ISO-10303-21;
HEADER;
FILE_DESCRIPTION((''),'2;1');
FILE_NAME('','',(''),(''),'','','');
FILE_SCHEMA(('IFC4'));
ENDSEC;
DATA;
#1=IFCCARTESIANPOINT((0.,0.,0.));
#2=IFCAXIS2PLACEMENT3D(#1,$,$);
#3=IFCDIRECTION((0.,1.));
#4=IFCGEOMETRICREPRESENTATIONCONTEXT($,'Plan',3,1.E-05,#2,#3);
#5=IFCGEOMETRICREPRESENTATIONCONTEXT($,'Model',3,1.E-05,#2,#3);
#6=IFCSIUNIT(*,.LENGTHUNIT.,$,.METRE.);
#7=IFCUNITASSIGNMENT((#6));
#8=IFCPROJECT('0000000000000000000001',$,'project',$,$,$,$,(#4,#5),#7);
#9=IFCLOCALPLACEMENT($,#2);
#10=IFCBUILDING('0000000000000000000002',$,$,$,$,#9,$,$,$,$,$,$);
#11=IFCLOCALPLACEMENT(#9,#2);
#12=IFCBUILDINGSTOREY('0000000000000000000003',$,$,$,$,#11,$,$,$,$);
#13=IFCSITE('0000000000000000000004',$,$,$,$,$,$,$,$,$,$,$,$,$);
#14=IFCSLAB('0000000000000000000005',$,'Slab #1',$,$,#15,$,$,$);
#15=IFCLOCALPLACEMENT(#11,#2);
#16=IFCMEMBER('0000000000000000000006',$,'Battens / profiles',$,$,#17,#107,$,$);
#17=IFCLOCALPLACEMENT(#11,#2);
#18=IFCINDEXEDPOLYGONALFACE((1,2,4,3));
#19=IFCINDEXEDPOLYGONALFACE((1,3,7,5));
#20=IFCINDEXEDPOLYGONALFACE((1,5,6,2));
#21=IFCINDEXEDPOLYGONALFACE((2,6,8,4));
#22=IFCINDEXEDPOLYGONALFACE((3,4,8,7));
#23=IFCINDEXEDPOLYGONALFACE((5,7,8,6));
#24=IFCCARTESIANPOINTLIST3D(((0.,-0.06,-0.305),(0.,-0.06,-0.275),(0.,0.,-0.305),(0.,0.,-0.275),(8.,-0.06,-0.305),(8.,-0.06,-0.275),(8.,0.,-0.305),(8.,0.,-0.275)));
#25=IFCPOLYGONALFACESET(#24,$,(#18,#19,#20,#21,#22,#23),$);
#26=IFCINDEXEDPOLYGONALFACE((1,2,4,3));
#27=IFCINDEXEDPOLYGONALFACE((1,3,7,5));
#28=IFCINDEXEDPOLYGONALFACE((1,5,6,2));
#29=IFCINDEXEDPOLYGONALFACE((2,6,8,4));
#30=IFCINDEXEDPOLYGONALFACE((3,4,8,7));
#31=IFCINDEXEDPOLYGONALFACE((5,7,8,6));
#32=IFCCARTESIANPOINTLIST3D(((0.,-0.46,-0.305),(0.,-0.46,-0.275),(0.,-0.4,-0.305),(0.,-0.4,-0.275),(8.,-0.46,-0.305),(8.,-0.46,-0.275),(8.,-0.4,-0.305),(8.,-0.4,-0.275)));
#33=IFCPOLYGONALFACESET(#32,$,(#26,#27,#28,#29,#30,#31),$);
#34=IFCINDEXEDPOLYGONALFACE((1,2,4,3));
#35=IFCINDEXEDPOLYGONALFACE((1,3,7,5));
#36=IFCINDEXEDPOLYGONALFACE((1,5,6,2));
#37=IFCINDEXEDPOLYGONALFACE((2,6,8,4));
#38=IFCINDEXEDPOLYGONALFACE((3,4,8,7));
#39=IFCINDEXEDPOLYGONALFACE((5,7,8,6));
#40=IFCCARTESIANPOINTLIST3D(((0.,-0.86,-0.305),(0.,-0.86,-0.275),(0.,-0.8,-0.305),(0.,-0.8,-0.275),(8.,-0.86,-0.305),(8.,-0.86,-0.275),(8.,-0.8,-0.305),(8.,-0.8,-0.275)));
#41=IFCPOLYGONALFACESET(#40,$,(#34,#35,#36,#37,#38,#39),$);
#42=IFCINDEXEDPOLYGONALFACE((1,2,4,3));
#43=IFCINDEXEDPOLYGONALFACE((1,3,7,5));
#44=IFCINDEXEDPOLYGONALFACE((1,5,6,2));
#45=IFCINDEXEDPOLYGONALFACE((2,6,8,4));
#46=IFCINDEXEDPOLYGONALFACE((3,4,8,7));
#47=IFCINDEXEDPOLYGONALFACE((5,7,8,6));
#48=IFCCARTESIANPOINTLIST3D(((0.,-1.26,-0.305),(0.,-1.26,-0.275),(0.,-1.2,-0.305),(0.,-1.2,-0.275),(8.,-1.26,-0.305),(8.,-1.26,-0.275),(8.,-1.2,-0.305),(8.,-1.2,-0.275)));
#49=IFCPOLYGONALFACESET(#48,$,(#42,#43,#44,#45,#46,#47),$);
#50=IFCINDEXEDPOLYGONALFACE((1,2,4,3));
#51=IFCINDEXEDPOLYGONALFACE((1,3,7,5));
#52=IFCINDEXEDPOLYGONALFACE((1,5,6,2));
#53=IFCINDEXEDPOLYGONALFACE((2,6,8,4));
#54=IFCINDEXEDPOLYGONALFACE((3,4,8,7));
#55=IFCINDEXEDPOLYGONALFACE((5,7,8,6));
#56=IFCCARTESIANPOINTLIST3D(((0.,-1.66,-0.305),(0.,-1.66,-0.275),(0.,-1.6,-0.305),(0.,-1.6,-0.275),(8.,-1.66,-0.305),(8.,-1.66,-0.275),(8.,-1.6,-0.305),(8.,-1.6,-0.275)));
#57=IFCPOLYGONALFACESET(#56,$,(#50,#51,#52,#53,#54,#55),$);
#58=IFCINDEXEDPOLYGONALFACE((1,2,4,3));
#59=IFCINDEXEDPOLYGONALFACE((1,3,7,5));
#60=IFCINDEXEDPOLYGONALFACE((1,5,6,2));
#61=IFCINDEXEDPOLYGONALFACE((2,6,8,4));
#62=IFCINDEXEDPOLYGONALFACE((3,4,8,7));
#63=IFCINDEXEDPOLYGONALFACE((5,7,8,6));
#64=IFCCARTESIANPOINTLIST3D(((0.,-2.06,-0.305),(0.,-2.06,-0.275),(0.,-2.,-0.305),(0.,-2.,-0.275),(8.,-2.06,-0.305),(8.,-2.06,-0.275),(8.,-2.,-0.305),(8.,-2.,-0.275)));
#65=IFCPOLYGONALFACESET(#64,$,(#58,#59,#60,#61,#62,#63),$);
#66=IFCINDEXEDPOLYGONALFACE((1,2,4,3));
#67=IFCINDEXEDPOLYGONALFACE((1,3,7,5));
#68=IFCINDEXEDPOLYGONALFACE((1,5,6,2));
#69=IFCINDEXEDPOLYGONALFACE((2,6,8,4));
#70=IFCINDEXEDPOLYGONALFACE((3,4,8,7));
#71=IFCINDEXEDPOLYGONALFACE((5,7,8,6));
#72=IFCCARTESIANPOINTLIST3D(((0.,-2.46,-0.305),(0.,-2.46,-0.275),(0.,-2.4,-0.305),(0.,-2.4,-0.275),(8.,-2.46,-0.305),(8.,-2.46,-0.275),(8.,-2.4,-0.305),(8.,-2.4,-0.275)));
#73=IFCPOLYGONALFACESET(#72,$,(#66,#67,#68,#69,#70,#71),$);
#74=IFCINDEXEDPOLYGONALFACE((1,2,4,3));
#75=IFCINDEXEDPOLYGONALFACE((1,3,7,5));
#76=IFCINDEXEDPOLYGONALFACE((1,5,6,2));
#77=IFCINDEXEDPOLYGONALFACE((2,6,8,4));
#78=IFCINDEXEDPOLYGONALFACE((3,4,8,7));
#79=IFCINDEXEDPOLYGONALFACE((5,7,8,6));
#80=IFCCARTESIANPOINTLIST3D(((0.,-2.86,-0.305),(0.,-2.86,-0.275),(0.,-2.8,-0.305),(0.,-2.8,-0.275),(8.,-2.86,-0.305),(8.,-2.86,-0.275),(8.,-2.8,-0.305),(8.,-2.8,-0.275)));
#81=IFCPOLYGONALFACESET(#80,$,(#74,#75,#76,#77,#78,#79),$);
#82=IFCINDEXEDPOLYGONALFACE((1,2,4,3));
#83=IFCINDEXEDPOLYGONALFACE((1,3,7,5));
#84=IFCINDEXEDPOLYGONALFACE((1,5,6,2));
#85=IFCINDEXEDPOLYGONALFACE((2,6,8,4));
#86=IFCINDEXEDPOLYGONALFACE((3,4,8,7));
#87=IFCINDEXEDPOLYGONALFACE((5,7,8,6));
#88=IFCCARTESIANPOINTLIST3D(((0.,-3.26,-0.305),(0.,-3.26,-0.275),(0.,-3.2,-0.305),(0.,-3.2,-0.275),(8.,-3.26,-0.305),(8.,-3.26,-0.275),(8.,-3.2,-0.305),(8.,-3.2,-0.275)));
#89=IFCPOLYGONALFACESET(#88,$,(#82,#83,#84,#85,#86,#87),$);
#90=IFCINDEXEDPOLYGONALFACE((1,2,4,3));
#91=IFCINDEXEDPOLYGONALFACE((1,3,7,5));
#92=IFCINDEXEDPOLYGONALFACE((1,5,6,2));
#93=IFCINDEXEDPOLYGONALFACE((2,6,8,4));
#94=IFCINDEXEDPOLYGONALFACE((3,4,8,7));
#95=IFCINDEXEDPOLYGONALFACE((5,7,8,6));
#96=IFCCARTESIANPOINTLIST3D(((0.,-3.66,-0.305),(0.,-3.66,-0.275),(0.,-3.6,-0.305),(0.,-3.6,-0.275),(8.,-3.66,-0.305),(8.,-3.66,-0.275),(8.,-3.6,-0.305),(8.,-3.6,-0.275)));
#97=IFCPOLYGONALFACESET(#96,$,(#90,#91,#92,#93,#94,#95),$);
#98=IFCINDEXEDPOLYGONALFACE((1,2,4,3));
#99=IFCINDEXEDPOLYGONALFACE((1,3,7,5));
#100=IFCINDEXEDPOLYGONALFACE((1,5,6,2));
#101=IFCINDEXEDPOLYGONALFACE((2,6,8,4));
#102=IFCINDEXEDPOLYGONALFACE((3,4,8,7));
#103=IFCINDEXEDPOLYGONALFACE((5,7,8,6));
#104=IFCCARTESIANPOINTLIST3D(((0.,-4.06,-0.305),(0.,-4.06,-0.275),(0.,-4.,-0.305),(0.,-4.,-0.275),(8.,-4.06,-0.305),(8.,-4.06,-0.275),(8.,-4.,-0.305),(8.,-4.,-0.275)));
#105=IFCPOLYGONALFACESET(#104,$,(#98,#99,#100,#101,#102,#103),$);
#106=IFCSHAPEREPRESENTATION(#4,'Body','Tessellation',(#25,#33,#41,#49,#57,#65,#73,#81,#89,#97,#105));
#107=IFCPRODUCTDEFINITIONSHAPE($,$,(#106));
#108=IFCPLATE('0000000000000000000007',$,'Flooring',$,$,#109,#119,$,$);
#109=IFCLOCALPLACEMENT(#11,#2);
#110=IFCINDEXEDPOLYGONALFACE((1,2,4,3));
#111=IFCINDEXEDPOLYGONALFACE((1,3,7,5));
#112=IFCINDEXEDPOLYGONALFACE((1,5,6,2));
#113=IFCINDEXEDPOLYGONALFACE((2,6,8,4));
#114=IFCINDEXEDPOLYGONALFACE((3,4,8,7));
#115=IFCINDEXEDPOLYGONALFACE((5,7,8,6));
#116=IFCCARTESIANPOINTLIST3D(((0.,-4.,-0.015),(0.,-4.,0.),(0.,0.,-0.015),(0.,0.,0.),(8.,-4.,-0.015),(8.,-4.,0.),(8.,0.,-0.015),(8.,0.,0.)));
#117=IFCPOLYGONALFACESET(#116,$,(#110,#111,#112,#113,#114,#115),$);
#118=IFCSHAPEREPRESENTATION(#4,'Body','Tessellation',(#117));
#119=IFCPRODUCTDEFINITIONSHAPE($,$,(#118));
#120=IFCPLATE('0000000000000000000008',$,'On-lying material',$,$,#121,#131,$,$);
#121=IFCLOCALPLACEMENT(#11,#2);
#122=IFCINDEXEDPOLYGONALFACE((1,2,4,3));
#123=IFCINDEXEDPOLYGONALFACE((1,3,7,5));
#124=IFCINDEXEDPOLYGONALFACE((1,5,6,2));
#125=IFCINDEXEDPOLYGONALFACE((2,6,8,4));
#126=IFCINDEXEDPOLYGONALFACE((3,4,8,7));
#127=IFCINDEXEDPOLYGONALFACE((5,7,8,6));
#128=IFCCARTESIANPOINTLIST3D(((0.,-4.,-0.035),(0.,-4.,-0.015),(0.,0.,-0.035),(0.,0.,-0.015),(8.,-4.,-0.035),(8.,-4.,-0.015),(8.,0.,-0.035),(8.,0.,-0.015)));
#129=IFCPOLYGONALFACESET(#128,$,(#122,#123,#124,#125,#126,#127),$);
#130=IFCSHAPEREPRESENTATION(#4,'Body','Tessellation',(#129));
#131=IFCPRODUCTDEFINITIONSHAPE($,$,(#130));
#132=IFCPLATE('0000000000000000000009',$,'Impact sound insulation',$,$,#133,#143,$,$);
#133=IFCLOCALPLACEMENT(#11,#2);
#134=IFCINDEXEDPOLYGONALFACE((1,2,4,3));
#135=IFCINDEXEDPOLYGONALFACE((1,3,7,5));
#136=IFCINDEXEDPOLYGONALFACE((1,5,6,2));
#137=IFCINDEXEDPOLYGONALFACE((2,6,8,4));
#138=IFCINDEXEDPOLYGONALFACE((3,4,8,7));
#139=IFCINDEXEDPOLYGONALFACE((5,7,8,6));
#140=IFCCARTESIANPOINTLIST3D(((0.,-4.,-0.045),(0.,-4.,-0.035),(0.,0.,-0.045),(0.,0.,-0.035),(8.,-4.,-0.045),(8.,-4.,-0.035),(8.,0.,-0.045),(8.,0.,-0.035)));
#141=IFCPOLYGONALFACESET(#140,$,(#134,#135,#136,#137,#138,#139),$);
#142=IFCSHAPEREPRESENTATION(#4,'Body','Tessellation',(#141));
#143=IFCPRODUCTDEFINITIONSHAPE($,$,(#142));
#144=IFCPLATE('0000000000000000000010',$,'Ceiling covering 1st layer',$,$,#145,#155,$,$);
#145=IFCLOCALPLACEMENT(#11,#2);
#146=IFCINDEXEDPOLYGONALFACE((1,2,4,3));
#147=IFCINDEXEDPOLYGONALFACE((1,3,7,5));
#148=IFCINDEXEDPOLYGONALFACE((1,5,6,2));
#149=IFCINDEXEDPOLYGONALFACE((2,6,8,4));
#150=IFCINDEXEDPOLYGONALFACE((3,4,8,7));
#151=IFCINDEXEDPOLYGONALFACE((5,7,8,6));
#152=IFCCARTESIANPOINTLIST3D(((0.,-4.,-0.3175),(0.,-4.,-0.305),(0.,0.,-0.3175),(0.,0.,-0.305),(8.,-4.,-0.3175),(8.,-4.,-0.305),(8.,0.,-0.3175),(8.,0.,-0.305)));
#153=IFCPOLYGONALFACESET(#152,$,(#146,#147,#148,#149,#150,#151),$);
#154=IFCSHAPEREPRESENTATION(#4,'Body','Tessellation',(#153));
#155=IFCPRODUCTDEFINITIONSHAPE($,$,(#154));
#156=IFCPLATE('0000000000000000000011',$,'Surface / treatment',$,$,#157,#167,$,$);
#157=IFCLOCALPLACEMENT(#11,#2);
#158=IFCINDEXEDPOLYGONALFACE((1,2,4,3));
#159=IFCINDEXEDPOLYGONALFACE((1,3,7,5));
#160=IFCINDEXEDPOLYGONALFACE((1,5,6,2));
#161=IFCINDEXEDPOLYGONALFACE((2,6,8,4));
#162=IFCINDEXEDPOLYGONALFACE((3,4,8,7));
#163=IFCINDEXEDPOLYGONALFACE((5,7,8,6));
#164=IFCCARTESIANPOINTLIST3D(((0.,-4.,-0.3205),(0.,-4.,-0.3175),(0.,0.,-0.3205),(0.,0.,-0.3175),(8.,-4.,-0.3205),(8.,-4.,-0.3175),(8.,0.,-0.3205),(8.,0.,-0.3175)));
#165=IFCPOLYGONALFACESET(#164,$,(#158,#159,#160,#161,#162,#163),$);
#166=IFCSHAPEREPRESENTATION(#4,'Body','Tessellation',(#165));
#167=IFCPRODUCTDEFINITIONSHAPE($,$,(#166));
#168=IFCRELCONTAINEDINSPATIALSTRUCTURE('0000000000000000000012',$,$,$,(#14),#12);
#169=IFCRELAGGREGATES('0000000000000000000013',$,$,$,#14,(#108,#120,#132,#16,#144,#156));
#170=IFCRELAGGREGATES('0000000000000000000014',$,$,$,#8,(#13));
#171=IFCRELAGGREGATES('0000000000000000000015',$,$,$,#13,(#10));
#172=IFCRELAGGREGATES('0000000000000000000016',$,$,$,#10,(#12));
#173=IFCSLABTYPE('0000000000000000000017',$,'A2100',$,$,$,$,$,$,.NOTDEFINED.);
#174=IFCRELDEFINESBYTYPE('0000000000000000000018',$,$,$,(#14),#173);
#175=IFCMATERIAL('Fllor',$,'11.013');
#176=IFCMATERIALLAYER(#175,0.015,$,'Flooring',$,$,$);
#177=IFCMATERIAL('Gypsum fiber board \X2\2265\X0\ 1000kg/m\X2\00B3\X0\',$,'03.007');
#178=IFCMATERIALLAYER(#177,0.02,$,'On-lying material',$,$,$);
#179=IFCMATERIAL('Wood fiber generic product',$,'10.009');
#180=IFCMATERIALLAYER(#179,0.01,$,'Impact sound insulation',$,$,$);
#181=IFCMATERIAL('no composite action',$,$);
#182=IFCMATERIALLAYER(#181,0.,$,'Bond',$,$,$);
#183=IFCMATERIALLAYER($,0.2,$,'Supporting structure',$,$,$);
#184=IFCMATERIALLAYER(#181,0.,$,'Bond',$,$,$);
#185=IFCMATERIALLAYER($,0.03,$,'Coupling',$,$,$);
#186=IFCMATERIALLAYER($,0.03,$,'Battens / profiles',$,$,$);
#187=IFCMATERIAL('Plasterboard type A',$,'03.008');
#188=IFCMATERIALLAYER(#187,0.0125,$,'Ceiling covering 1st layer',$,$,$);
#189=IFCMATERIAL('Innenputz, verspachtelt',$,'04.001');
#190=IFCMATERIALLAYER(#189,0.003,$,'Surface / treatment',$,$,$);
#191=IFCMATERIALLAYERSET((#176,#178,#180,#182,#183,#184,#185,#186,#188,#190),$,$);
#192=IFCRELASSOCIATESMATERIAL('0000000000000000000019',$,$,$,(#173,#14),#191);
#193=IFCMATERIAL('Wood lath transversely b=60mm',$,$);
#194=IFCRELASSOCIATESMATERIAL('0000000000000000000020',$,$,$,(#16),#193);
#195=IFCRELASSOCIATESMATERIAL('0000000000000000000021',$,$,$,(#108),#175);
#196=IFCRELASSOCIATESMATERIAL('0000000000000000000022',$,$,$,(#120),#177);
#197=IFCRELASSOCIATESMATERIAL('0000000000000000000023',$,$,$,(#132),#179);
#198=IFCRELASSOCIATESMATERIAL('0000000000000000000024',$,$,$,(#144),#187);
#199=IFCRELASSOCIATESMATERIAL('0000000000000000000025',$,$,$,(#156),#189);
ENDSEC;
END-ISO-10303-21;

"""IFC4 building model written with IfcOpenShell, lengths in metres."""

from ifc_helpers import new_model, si_unit, direction, frame, frame_2d, origin, origin_with_axes, place, context, project, spatial, rectangle, extrude, material, layer, layer_set, type_object, element, aggregate, save


model = new_model("IFC4")

# Units and contexts
plan_context = context("Plan", 3, precision=1e-05, world=origin(), true_north=direction((0.0, 1.0)))
model_context = context("Model", 3, precision=1e-05, world=origin(), true_north=direction((0.0, 1.0)))
ifc_project = project(units=[si_unit("LENGTHUNIT", "METRE")], contexts=[plan_context, model_context])

# Site, building, storey
site = spatial("IfcSite", under=ifc_project)
building_placement = place(None, origin())
building = spatial("IfcBuilding", under=site, at=building_placement)
storey_placement = place(building_placement, origin())
storey = spatial("IfcBuildingStorey", under=building, at=storey_placement)

# Slab, member, plates
ifc_material_1 = material(Name="Fllor", Category="11.013")
ifc_layer_1 = layer(ifc_material_1, 0.015, Name="Flooring")
ifc_material_2 = material(Name="Gypsum fiber board ≥ 1000kg/m³", Category="03.007")
ifc_layer_2 = layer(ifc_material_2, 0.02, Name="On-lying material")
ifc_material_3 = material(Name="Wood fiber generic product", Category="10.009")
ifc_layer_3 = layer(ifc_material_3, 0.01, Name="Impact sound insulation")
ifc_material_4 = material(Name="no composite action")
ifc_layer_4 = layer(ifc_material_4, 0.0, Name="Bond")
ifc_layer_5 = layer(None, 0.2, Name="Supporting structure")
ifc_layer_6 = layer(ifc_material_4, 0.0, Name="Bond")
ifc_layer_7 = layer(None, 0.03, Name="Coupling")
ifc_layer_8 = layer(None, 0.03, Name="Battens / profiles")
ifc_material_5 = material(Name="Plasterboard type A", Category="03.008")
ifc_layer_9 = layer(ifc_material_5, 0.0125, Name="Ceiling covering 1st layer")
ifc_material_6 = material(Name="Innenputz, verspachtelt", Category="04.001")
ifc_layer_10 = layer(ifc_material_6, 0.003, Name="Surface / treatment")
ifc_layer_set = layer_set([ifc_layer_1, ifc_layer_2, ifc_layer_3, ifc_layer_4, ifc_layer_5, ifc_layer_6, ifc_layer_7, ifc_layer_8, ifc_layer_9, ifc_layer_10])
slab_type = type_object("IfcSlabType", Name="A2100", PredefinedType="NOTDEFINED", material=ifc_layer_set)
slab_placement = place(None, frame((0.0, 0.0, 0.0), z_axis=(0.0, 0.0, -1.0), x_axis=(1.0, 0.0, 0.0)))
slab = element("IfcSlab", 1, at=slab_placement, inside=storey, type_object=slab_type, material=ifc_layer_set, Name="Slab #1")
ifc_material_7 = material(Name="Wood lath transversely b=60mm")
member_1_placement = place(slab_placement, origin())
member_1 = element("IfcMember", 2, at=member_1_placement, material=ifc_material_7, Name="Battens / profiles", context=plan_context, shape_type="SweptSolid", body=[
    extrude(rectangle(XDim=0.06, YDim=0.03, at=frame_2d((0.03, 0.015), x_axis=(1.0, 0.0))), frame((0.0, 0.0, 0.275), z_axis=(1.0, 0.0, 0.0), x_axis=(0.0, 1.0, 0.0)), (0.0, 0.0, 1.0), 8.0),
    extrude(rectangle(XDim=0.06, YDim=0.03, at=frame_2d((0.03, 0.015), x_axis=(1.0, 0.0))), frame((0.0, 0.4, 0.275), z_axis=(1.0, 0.0, 0.0), x_axis=(0.0, 1.0, 0.0)), (0.0, 0.0, 1.0), 8.0),
    extrude(rectangle(XDim=0.06, YDim=0.03, at=frame_2d((0.03, 0.015), x_axis=(1.0, 0.0))), frame((0.0, 0.8, 0.275), z_axis=(1.0, 0.0, 0.0), x_axis=(0.0, 1.0, 0.0)), (0.0, 0.0, 1.0), 8.0),
    extrude(rectangle(XDim=0.06, YDim=0.03, at=frame_2d((0.03, 0.015), x_axis=(1.0, 0.0))), frame((0.0, 1.2, 0.275), z_axis=(1.0, 0.0, 0.0), x_axis=(0.0, 1.0, 0.0)), (0.0, 0.0, 1.0), 8.0),
    extrude(rectangle(XDim=0.06, YDim=0.03, at=frame_2d((0.03, 0.015), x_axis=(1.0, 0.0))), frame((0.0, 1.6, 0.275), z_axis=(1.0, 0.0, 0.0), x_axis=(0.0, 1.0, 0.0)), (0.0, 0.0, 1.0), 8.0),
    extrude(rectangle(XDim=0.06, YDim=0.03, at=frame_2d((0.03, 0.015), x_axis=(1.0, 0.0))), frame((0.0, 2.0, 0.275), z_axis=(1.0, 0.0, 0.0), x_axis=(0.0, 1.0, 0.0)), (0.0, 0.0, 1.0), 8.0),
    extrude(rectangle(XDim=0.06, YDim=0.03, at=frame_2d((0.03, 0.015), x_axis=(1.0, 0.0))), frame((0.0, 2.4, 0.275), z_axis=(1.0, 0.0, 0.0), x_axis=(0.0, 1.0, 0.0)), (0.0, 0.0, 1.0), 8.0),
    extrude(rectangle(XDim=0.06, YDim=0.03, at=frame_2d((0.03, 0.015), x_axis=(1.0, 0.0))), frame((0.0, 2.8, 0.275), z_axis=(1.0, 0.0, 0.0), x_axis=(0.0, 1.0, 0.0)), (0.0, 0.0, 1.0), 8.0),
    extrude(rectangle(XDim=0.06, YDim=0.03, at=frame_2d((0.03, 0.015), x_axis=(1.0, 0.0))), frame((0.0, 3.2, 0.275), z_axis=(1.0, 0.0, 0.0), x_axis=(0.0, 1.0, 0.0)), (0.0, 0.0, 1.0), 8.0),
    extrude(rectangle(XDim=0.06, YDim=0.03, at=frame_2d((0.03, 0.015), x_axis=(1.0, 0.0))), frame((0.0, 3.6, 0.275), z_axis=(1.0, 0.0, 0.0), x_axis=(0.0, 1.0, 0.0)), (0.0, 0.0, 1.0), 8.0),
    extrude(rectangle(XDim=0.06, YDim=0.03, at=frame_2d((0.03, 0.015), x_axis=(1.0, 0.0))), frame((0.0, 4.0, 0.275), z_axis=(1.0, 0.0, 0.0), x_axis=(0.0, 1.0, 0.0)), (0.0, 0.0, 1.0), 8.0),
])
plate_1_placement = place(slab_placement, origin())
plate_1 = element("IfcPlate", 3, at=plate_1_placement, material=ifc_material_1, Name="Flooring", context=plan_context, shape_type="SweptSolid", body=[
    extrude(rectangle(XDim=8.0, YDim=4.0, at=frame_2d((4.0, 2.0), x_axis=(1.0, 0.0))), origin_with_axes(), (0.0, 0.0, 1.0), 0.015),
])
plate_2_placement = place(slab_placement, origin())
plate_2 = element("IfcPlate", 4, at=plate_2_placement, material=ifc_material_2, Name="On-lying material", context=plan_context, shape_type="SweptSolid", body=[
    extrude(rectangle(XDim=8.0, YDim=4.0, at=frame_2d((4.0, 2.0), x_axis=(1.0, 0.0))), frame((0.0, 0.0, 0.015), z_axis=(0.0, 0.0, 1.0), x_axis=(1.0, 0.0, 0.0)), (0.0, 0.0, 1.0), 0.02),
])
plate_3_placement = place(slab_placement, origin())
plate_3 = element("IfcPlate", 5, at=plate_3_placement, material=ifc_material_3, Name="Impact sound insulation", context=plan_context, shape_type="SweptSolid", body=[
    extrude(rectangle(XDim=8.0, YDim=4.0, at=frame_2d((4.0, 2.0), x_axis=(1.0, 0.0))), frame((0.0, 0.0, 0.035), z_axis=(0.0, 0.0, 1.0), x_axis=(1.0, 0.0, 0.0)), (0.0, 0.0, 1.0), 0.01),
])
plate_4_placement = place(slab_placement, origin())
plate_4 = element("IfcPlate", 6, at=plate_4_placement, material=ifc_material_5, Name="Ceiling covering 1st layer", context=plan_context, shape_type="SweptSolid", body=[
    extrude(rectangle(XDim=8.0, YDim=4.0, at=frame_2d((4.0, 2.0), x_axis=(1.0, 0.0))), frame((0.0, 0.0, 0.305), z_axis=(0.0, 0.0, 1.0), x_axis=(1.0, 0.0, 0.0)), (0.0, 0.0, 1.0), 0.0125),
])
plate_5_placement = place(slab_placement, origin())
plate_5 = element("IfcPlate", 7, at=plate_5_placement, material=ifc_material_6, Name="Surface / treatment", context=plan_context, shape_type="SweptSolid", body=[
    extrude(rectangle(XDim=8.0, YDim=4.0, at=frame_2d((4.0, 2.0), x_axis=(1.0, 0.0))), frame((0.0, 0.0, 0.3175), z_axis=(0.0, 0.0, 1.0), x_axis=(1.0, 0.0, 0.0)), (0.0, 0.0, 1.0), 0.003),
])
aggregate(slab, [plate_1, plate_2, plate_3, member_1, plate_4, plate_5])

save(model, "model.ifc")
